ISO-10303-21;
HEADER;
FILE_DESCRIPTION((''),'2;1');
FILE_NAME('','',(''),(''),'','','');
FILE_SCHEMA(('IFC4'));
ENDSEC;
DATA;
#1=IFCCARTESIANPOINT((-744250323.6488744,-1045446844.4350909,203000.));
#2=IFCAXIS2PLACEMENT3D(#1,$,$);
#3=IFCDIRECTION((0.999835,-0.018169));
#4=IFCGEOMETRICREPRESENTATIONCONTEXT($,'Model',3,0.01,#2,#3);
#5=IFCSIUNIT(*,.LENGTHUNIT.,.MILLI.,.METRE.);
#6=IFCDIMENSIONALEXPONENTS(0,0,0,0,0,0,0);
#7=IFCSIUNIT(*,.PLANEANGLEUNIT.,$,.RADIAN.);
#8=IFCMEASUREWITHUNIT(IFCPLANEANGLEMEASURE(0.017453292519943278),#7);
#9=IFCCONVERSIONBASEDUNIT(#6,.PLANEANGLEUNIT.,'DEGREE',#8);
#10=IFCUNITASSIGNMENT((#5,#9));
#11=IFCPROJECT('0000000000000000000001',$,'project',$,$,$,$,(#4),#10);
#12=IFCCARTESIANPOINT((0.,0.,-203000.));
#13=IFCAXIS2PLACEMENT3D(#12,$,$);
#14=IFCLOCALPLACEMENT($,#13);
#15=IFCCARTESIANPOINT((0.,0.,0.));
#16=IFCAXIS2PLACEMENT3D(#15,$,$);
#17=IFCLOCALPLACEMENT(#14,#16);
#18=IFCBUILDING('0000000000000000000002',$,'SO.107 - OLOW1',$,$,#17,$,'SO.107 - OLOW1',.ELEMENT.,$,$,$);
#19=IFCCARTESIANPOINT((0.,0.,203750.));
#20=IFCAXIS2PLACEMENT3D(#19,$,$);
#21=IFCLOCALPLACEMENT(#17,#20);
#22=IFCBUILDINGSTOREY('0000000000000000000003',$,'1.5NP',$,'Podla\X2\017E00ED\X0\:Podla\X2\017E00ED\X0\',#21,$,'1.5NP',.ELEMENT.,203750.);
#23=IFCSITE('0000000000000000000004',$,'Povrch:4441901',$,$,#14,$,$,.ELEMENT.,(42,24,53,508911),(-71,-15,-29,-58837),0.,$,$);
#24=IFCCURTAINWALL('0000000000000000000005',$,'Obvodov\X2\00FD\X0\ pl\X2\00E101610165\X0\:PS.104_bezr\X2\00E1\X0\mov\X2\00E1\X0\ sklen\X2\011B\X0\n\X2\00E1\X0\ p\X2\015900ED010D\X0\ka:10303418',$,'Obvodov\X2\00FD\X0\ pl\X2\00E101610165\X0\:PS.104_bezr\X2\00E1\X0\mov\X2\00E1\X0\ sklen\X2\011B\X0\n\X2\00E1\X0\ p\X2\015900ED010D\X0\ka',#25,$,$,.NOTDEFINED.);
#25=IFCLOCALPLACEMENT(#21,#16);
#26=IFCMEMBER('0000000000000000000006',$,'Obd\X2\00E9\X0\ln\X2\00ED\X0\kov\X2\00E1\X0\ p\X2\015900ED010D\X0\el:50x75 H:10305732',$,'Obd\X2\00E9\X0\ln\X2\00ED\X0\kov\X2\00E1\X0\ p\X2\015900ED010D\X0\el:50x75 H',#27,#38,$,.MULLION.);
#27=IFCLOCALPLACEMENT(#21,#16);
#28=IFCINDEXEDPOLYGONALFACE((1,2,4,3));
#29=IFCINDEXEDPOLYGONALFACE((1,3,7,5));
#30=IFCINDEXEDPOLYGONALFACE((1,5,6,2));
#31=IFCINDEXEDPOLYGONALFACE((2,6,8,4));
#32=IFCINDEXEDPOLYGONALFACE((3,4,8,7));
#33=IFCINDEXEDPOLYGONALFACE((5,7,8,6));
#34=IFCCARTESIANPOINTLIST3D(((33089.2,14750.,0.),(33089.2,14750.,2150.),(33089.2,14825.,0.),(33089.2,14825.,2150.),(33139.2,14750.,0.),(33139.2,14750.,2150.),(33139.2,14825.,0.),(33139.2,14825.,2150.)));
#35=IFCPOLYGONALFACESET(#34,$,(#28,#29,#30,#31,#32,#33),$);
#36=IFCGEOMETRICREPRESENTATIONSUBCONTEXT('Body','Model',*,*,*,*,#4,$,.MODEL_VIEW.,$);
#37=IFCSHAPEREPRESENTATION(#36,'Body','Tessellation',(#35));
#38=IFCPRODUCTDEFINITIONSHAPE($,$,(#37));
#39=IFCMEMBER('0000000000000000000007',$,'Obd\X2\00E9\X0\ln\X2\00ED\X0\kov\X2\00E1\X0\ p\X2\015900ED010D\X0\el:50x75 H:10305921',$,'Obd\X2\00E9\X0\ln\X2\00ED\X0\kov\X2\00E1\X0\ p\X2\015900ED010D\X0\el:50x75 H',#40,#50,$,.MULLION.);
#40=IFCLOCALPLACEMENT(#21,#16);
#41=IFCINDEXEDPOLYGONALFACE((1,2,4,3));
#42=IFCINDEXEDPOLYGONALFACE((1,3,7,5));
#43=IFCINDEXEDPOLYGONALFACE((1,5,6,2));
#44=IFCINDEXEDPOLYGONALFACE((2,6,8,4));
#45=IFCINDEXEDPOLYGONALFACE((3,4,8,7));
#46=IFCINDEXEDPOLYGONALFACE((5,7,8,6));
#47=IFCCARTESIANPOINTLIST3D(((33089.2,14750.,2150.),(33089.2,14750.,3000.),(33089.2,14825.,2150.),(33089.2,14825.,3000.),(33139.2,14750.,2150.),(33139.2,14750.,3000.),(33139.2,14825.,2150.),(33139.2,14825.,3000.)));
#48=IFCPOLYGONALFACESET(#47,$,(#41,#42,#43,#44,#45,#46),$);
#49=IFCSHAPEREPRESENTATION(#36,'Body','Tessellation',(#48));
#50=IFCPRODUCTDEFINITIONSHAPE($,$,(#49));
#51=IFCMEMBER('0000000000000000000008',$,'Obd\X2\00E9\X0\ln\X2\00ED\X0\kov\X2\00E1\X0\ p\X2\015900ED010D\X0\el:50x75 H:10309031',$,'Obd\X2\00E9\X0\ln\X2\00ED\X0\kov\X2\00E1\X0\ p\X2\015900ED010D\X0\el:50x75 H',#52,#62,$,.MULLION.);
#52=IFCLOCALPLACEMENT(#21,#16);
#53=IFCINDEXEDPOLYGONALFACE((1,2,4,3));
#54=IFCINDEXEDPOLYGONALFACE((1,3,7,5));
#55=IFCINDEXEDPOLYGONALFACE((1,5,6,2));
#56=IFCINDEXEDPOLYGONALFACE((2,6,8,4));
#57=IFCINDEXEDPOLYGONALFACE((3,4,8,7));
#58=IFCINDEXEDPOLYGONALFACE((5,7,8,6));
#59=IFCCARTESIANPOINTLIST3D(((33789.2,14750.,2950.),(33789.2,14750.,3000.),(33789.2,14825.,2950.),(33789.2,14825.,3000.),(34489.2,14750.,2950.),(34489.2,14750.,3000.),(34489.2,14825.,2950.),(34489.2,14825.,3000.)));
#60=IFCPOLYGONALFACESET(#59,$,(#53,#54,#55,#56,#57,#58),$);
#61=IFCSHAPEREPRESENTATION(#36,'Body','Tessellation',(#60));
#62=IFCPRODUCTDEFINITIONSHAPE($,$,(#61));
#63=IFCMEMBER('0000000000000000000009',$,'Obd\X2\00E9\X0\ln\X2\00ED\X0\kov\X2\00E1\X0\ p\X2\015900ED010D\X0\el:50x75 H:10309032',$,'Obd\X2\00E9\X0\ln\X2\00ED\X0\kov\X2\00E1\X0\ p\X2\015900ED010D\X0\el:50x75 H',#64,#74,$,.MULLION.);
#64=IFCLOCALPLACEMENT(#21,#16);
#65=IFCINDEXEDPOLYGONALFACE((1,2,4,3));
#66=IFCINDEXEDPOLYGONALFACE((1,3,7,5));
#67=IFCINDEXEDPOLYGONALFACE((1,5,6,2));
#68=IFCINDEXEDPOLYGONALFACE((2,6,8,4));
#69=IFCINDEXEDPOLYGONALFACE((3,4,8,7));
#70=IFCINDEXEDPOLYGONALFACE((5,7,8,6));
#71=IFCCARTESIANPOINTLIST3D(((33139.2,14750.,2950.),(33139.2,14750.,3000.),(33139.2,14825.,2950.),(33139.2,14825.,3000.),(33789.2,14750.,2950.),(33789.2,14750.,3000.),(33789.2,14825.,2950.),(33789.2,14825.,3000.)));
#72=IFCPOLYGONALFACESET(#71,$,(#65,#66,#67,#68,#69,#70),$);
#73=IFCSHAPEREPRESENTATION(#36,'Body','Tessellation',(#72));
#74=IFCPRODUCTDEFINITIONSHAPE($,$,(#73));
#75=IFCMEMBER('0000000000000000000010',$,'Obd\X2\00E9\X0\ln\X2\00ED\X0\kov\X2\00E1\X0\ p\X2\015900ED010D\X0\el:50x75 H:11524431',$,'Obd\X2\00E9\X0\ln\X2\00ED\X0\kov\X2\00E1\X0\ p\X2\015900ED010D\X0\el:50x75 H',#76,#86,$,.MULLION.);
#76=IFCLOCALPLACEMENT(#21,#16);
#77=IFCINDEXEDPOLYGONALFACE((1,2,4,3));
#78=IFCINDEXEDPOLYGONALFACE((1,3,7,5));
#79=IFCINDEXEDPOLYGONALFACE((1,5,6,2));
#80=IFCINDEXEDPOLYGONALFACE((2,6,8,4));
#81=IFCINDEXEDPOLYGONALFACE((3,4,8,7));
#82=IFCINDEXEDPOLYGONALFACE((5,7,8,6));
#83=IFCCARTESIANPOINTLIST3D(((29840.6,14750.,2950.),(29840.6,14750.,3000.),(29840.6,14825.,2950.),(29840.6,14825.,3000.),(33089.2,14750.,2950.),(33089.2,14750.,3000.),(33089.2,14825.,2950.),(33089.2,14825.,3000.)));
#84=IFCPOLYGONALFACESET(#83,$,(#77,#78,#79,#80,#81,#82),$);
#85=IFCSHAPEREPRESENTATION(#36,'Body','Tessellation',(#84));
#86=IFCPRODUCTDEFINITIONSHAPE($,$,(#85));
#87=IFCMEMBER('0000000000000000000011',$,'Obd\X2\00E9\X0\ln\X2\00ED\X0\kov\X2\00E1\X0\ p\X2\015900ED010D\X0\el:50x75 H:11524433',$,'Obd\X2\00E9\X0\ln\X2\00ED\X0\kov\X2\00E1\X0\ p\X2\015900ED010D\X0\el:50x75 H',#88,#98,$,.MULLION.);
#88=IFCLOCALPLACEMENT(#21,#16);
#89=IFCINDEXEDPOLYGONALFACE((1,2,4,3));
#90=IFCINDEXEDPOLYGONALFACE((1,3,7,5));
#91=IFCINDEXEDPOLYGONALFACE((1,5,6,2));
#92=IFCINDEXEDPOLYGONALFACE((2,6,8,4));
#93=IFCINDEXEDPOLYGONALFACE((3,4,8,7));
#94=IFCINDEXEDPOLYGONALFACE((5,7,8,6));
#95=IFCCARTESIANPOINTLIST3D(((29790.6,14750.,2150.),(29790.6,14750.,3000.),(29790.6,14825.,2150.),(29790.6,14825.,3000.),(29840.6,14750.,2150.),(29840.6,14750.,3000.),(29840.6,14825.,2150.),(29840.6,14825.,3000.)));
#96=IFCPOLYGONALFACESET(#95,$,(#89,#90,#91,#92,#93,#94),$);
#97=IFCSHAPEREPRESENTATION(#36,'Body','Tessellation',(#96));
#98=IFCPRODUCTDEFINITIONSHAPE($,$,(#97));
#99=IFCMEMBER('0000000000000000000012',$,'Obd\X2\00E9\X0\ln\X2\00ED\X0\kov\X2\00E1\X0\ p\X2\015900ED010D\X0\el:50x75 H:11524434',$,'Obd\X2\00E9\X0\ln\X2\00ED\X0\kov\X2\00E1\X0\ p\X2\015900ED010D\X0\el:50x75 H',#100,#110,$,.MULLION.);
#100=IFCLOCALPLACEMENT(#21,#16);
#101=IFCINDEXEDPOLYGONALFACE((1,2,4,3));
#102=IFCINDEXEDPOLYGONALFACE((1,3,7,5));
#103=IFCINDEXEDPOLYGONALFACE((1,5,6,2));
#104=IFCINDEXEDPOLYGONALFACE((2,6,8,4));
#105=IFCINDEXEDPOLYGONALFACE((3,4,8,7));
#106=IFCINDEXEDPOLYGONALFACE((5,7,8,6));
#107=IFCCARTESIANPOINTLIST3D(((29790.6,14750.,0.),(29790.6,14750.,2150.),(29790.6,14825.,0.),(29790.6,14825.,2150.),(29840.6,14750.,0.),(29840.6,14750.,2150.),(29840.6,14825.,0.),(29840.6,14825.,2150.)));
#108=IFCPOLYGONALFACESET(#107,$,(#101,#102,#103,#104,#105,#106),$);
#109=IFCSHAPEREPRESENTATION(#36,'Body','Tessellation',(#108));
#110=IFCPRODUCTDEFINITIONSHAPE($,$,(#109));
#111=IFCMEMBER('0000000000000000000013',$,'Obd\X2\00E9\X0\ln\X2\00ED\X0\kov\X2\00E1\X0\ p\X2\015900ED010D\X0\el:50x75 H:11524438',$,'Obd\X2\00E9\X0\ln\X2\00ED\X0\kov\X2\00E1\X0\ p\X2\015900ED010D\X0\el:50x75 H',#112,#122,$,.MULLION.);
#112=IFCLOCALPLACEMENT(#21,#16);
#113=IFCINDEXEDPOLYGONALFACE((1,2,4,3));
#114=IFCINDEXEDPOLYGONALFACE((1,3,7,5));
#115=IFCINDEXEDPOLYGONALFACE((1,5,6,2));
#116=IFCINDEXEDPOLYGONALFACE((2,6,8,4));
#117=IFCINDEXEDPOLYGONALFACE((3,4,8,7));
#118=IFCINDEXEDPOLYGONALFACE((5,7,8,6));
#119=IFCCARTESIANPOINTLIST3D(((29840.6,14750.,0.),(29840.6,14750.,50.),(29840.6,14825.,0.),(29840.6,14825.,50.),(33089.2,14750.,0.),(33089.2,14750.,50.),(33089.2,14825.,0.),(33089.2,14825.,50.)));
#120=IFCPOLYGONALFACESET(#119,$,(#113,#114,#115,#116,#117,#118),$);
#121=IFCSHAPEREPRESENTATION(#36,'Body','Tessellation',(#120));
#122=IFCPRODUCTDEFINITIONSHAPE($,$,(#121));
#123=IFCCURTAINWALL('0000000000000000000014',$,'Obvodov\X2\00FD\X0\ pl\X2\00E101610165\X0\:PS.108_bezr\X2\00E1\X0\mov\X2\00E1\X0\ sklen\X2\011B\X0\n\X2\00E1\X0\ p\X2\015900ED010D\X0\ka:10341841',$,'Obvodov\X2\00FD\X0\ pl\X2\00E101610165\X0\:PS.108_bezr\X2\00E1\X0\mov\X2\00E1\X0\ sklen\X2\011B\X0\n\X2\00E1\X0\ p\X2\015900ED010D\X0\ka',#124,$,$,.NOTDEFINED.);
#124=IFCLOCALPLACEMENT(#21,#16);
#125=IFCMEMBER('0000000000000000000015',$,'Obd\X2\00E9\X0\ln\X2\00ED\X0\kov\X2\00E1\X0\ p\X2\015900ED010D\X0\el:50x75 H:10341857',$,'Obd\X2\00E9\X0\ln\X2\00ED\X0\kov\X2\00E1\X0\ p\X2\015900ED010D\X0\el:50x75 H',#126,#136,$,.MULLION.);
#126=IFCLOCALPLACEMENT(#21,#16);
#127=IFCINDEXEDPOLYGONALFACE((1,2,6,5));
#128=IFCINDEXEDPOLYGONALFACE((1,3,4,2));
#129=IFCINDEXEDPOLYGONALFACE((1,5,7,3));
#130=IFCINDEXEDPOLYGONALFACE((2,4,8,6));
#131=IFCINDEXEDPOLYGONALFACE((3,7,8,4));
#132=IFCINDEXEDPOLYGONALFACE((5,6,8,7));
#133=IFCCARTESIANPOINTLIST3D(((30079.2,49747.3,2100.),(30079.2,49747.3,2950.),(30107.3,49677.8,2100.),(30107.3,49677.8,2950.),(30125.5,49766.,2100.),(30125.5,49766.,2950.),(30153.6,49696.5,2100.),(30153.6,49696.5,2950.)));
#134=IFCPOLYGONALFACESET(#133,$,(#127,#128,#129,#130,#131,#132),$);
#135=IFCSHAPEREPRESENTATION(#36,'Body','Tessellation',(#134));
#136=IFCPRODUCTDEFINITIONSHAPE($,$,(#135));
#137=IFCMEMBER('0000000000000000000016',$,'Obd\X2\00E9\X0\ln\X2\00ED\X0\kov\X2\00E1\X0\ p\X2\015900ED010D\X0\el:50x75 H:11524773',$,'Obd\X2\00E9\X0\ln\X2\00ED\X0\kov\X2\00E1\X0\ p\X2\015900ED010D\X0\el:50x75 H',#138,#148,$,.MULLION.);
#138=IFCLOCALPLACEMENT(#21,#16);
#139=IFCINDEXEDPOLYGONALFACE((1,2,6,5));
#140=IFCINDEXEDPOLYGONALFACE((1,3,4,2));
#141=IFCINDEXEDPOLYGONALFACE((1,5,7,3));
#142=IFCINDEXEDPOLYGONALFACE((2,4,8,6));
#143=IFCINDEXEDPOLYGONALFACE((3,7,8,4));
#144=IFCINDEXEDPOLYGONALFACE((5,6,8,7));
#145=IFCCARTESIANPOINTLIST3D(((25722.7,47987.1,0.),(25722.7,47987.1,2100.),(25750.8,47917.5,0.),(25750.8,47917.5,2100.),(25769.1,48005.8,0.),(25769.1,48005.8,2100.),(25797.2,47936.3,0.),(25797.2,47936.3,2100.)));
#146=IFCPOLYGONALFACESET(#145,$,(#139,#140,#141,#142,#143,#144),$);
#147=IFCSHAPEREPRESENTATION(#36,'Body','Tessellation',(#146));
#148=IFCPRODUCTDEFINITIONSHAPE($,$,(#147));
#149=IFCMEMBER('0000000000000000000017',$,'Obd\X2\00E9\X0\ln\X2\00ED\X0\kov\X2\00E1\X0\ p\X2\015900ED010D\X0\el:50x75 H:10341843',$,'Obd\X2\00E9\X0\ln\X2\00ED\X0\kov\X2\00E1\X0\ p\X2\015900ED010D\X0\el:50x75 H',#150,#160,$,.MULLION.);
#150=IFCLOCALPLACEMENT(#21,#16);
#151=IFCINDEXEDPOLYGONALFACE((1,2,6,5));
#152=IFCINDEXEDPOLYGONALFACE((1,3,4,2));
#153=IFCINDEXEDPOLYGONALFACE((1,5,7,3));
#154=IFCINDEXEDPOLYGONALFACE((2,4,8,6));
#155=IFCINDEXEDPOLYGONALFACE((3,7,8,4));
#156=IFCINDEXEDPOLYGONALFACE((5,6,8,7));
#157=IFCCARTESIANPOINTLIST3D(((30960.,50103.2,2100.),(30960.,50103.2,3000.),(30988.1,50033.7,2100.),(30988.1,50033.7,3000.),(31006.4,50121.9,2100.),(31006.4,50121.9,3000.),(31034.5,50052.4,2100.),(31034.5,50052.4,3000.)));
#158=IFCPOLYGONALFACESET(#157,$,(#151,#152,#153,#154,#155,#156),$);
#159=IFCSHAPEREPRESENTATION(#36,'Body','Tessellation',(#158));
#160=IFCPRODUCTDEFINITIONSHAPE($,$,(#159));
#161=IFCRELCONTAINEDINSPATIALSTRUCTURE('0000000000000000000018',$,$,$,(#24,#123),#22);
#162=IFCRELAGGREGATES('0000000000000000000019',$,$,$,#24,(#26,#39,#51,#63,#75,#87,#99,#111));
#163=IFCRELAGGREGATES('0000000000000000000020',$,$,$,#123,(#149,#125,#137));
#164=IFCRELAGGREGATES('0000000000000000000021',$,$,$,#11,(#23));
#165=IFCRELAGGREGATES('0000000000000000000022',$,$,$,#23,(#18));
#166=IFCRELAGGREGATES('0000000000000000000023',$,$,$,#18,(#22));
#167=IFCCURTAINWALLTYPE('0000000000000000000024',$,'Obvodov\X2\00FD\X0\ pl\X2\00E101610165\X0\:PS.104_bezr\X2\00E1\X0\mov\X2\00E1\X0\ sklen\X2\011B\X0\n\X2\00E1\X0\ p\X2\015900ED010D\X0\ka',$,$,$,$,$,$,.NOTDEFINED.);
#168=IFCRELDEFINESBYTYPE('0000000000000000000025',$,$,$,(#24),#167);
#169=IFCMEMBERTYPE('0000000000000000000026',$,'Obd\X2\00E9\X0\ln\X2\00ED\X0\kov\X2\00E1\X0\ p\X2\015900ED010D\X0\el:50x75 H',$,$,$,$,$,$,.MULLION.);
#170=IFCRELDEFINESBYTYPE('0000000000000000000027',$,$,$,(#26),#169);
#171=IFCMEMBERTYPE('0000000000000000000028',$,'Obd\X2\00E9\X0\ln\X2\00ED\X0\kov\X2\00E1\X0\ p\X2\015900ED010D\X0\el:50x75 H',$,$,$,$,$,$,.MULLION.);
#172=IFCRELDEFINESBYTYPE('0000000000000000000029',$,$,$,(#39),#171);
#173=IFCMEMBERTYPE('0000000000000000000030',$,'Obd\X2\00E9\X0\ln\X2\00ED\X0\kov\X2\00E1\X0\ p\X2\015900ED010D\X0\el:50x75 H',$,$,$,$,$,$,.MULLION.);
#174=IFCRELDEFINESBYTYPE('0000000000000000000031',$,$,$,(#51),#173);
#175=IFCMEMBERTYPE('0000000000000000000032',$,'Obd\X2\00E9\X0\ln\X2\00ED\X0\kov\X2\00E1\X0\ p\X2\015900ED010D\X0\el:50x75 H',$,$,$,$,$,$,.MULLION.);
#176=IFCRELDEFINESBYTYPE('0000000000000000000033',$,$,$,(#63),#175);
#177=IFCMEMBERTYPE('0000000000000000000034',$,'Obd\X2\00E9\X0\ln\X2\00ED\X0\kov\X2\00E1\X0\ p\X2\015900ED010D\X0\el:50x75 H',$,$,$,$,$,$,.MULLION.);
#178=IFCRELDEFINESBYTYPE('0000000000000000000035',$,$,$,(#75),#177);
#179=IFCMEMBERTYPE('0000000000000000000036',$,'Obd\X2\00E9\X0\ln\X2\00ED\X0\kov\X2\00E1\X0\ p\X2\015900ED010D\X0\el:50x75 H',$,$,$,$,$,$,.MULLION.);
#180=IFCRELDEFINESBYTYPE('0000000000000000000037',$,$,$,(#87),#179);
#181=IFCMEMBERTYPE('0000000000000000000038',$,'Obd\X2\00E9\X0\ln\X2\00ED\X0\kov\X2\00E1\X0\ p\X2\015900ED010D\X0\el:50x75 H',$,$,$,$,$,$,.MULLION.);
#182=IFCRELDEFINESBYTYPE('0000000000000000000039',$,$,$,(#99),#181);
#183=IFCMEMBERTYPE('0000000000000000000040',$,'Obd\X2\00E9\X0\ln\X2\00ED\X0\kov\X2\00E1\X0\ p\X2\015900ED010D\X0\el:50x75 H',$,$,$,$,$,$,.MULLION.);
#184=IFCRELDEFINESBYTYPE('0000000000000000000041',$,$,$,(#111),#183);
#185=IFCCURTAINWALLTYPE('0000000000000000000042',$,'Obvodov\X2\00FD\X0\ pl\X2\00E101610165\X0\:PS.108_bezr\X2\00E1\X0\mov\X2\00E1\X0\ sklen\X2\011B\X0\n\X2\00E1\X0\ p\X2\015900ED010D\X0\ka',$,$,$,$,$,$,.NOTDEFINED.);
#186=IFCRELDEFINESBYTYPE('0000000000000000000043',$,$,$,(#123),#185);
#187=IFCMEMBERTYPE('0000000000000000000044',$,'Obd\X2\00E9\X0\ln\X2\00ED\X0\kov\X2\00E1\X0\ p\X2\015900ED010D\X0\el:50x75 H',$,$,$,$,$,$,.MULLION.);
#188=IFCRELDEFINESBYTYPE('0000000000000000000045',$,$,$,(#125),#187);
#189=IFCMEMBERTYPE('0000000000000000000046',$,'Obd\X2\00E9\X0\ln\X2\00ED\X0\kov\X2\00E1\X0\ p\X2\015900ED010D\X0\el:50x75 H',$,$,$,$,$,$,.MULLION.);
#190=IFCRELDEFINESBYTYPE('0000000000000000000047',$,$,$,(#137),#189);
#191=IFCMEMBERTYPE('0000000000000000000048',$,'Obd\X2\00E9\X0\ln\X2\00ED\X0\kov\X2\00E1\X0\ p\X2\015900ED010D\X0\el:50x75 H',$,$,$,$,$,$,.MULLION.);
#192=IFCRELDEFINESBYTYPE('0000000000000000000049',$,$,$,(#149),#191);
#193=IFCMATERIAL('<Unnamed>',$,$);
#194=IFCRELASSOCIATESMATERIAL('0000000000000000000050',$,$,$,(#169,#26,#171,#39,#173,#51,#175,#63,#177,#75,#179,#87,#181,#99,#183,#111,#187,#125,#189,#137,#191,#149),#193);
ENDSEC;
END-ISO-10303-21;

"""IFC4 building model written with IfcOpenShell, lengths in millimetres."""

from ifc_helpers import new_model, entity, si_unit, converted_unit, direction, frame, origin, place, context, subcontext, project, spatial, indexed_curve, outline, extrude, source, transform, mapped, material, type_object, type_shapes, element, aggregate, save


model = new_model("IFC4")

# Units and contexts
model_context = context("Model", 3, precision=0.01, world=frame((-744250323.6488744, -1045446844.4350909, 203000.0)), true_north=direction((0.999835, -0.018169)))
body_context = subcontext(model_context, "Body", "Model", "MODEL_VIEW")
ifc_project = project(units=[si_unit("LENGTHUNIT", "METRE", prefix="MILLI"), converted_unit("PLANEANGLEUNIT", "DEGREE", entity("IfcPlaneAngleMeasure", 0.017453292519943278), si_unit("PLANEANGLEUNIT", "RADIAN"), dimensions=[0, 0, 0, 0, 0, 0, 0])], contexts=[model_context])

# Site, building, storey
site_placement = place(None, frame((0.0, 0.0, -203000.0)))
site = spatial("IfcSite", under=ifc_project, at=site_placement, Name="Povrch:4441901", CompositionType="ELEMENT", RefLatitude=(42, 24, 53, 508911), RefLongitude=(-71, -15, -29, -58837), RefElevation=0.0)
building_placement = place(site_placement, origin())
building = spatial("IfcBuilding", under=site, at=building_placement, Name="SO.107 - OLOW1", LongName="SO.107 - OLOW1", CompositionType="ELEMENT")
storey_placement = place(building_placement, frame((0.0, 0.0, 203750.0)))
storey = spatial("IfcBuildingStorey", under=building, at=storey_placement, Name="1.5NP", ObjectType="Podlaží:Podlaží", LongName="1.5NP", CompositionType="ELEMENT", Elevation=203750.0)

# Curtain walls, members
curtain_wall_type_1 = type_object("IfcCurtainWallType", Name="Obvodový plášť:PS.104_bezrámová skleněná příčka", PredefinedType="NOTDEFINED")
curtain_wall_1_placement = place(storey_placement, frame((0.0, 0.0, -203750.0)))
curtain_wall_1 = element("IfcCurtainWall", 1, at=curtain_wall_1_placement, inside=storey, type_object=curtain_wall_type_1, Name="Obvodový plášť:PS.104_bezrámová skleněná příčka:10303418", ObjectType="Obvodový plášť:PS.104_bezrámová skleněná příčka", PredefinedType="NOTDEFINED")
ifc_material_1 = material(Name="<Unnamed>")
member_type_1 = type_object("IfcMemberType", Name="Obdélníková příčel:50x75 H", PredefinedType="MULLION", material=ifc_material_1)
shared_shape_1 = source(origin(), body_context, "Body", "SweptSolid", [
    extrude(outline(indexed_curve([(-25.0, -37.5), (25.0, -37.5), (25.0, 37.5), (-25.0, 37.5), (-25.0, -37.5)], self_intersect=False)), frame((-25.0, 37.5, -2150.0), z_axis=(0.0, 0.0, 1.0), x_axis=(-1.0, 0.0, 0.0)), (0.0, 0.0, 1.0), 2150.0),
])
type_shapes(member_type_1, [shared_shape_1])
member_1_placement = place(curtain_wall_1_placement, frame((33089.2, 14750.0, 203750.0), z_axis=(0.0, 0.0, -1.0), x_axis=(-1.0, 0.0, 0.0)))
member_1 = element("IfcMember", 2, at=member_1_placement, type_object=member_type_1, material=ifc_material_1, Name="Obdélníková příčel:50x75 H:10305732", ObjectType="Obdélníková příčel:50x75 H", PredefinedType="MULLION", context=body_context, shape_type="MappedRepresentation", body=[
    mapped(shared_shape_1, transform((0.0, 0.0, 0.0), scale=1.0)),
])
member_type_2 = type_object("IfcMemberType", Name="Obdélníková příčel:50x75 H", PredefinedType="MULLION", material=ifc_material_1)
shared_shape_2 = source(origin(), body_context, "Body", "SweptSolid", [
    extrude(outline(indexed_curve([(-25.0, -37.5), (25.0, -37.5), (25.0, 37.5), (-25.0, 37.5), (-25.0, -37.5)], self_intersect=False)), frame((-25.0, 37.5, -850.0), z_axis=(0.0, 0.0, 1.0), x_axis=(-1.0, 0.0, 0.0)), (0.0, 0.0, 1.0), 850.0),
])
type_shapes(member_type_2, [shared_shape_2])
member_2_placement = place(curtain_wall_1_placement, frame((33089.2, 14750.0, 205900.0), z_axis=(0.0, 0.0, -1.0), x_axis=(-1.0, 0.0, 0.0)))
member_2 = element("IfcMember", 3, at=member_2_placement, type_object=member_type_2, material=ifc_material_1, Name="Obdélníková příčel:50x75 H:10305921", ObjectType="Obdélníková příčel:50x75 H", PredefinedType="MULLION", context=body_context, shape_type="MappedRepresentation", body=[
    mapped(shared_shape_2, transform((0.0, 0.0, 0.0), scale=1.0)),
])
member_type_3 = type_object("IfcMemberType", Name="Obdélníková příčel:50x75 H", PredefinedType="MULLION", material=ifc_material_1)
shared_shape_3 = source(origin(), body_context, "Body", "SweptSolid", [
    extrude(outline(indexed_curve([(-25.0, -37.5), (25.0, -37.5), (25.0, 37.5), (-25.0, 37.5), (-25.0, -37.5)], self_intersect=False)), frame((-25.0, 37.5, -700.0), z_axis=(0.0, 0.0, 1.0), x_axis=(-1.0, 0.0, 0.0)), (0.0, 0.0, 1.0), 700.0),
])
type_shapes(member_type_3, [shared_shape_3])
member_3_placement = place(curtain_wall_1_placement, frame((33789.2, 14750.0, 206750.0), z_axis=(-1.0, 0.0, 0.0), x_axis=(0.0, 0.0, 1.0)))
member_3 = element("IfcMember", 4, at=member_3_placement, type_object=member_type_3, material=ifc_material_1, Name="Obdélníková příčel:50x75 H:10309031", ObjectType="Obdélníková příčel:50x75 H", PredefinedType="MULLION", context=body_context, shape_type="MappedRepresentation", body=[
    mapped(shared_shape_3, transform((0.0, 0.0, 0.0), scale=1.0)),
])
member_type_4 = type_object("IfcMemberType", Name="Obdélníková příčel:50x75 H", PredefinedType="MULLION", material=ifc_material_1)
shared_shape_4 = source(origin(), body_context, "Body", "SweptSolid", [
    extrude(outline(indexed_curve([(-25.0, -37.5), (25.0, -37.5), (25.0, 37.5), (-25.0, 37.5), (-25.0, -37.5)], self_intersect=False)), frame((-25.0, 37.5, -650.0), z_axis=(0.0, 0.0, 1.0), x_axis=(-1.0, 0.0, 0.0)), (0.0, 0.0, 1.0), 650.0),
])
type_shapes(member_type_4, [shared_shape_4])
member_4_placement = place(curtain_wall_1_placement, frame((33139.2, 14750.0, 206750.0), z_axis=(-1.0, 0.0, 0.0), x_axis=(0.0, 0.0, 1.0)))
member_4 = element("IfcMember", 5, at=member_4_placement, type_object=member_type_4, material=ifc_material_1, Name="Obdélníková příčel:50x75 H:10309032", ObjectType="Obdélníková příčel:50x75 H", PredefinedType="MULLION", context=body_context, shape_type="MappedRepresentation", body=[
    mapped(shared_shape_4, transform((0.0, 0.0, 0.0), scale=1.0)),
])
member_type_5 = type_object("IfcMemberType", Name="Obdélníková příčel:50x75 H", PredefinedType="MULLION", material=ifc_material_1)
shared_shape_5 = source(origin(), body_context, "Body", "SweptSolid", [
    extrude(outline(indexed_curve([(-25.0, -37.5), (25.0, -37.5), (25.0, 37.5), (-25.0, 37.5), (-25.0, -37.5)], self_intersect=False)), frame((-25.0, 37.5, -3248.6), z_axis=(0.0, 0.0, 1.0), x_axis=(-1.0, 0.0, 0.0)), (0.0, 0.0, 1.0), 3248.6),
])
type_shapes(member_type_5, [shared_shape_5])
member_5_placement = place(curtain_wall_1_placement, frame((29840.6, 14750.0, 206750.0), z_axis=(-1.0, 0.0, 0.0), x_axis=(0.0, 0.0, 1.0)))
member_5 = element("IfcMember", 6, at=member_5_placement, type_object=member_type_5, material=ifc_material_1, Name="Obdélníková příčel:50x75 H:11524431", ObjectType="Obdélníková příčel:50x75 H", PredefinedType="MULLION", context=body_context, shape_type="MappedRepresentation", body=[
    mapped(shared_shape_5, transform((0.0, 0.0, 0.0), scale=1.0)),
])
member_type_6 = type_object("IfcMemberType", Name="Obdélníková příčel:50x75 H", PredefinedType="MULLION", material=ifc_material_1)
shared_shape_6 = source(origin(), body_context, "Body", "SweptSolid", [
    extrude(outline(indexed_curve([(-25.0, -37.5), (25.0, -37.5), (25.0, 37.5), (-25.0, 37.5), (-25.0, -37.5)], self_intersect=False)), frame((-25.0, 37.5, -850.0), z_axis=(0.0, 0.0, 1.0), x_axis=(-1.0, 0.0, 0.0)), (0.0, 0.0, 1.0), 850.0),
])
type_shapes(member_type_6, [shared_shape_6])
member_6_placement = place(curtain_wall_1_placement, frame((29790.6, 14750.0, 205900.0), z_axis=(0.0, 0.0, -1.0), x_axis=(-1.0, 0.0, 0.0)))
member_6 = element("IfcMember", 7, at=member_6_placement, type_object=member_type_6, material=ifc_material_1, Name="Obdélníková příčel:50x75 H:11524433", ObjectType="Obdélníková příčel:50x75 H", PredefinedType="MULLION", context=body_context, shape_type="MappedRepresentation", body=[
    mapped(shared_shape_6, transform((0.0, 0.0, 0.0), scale=1.0)),
])
member_type_7 = type_object("IfcMemberType", Name="Obdélníková příčel:50x75 H", PredefinedType="MULLION", material=ifc_material_1)
shared_shape_7 = source(origin(), body_context, "Body", "SweptSolid", [
    extrude(outline(indexed_curve([(-25.0, -37.5), (25.0, -37.5), (25.0, 37.5), (-25.0, 37.5), (-25.0, -37.5)], self_intersect=False)), frame((-25.0, 37.5, -2150.0), z_axis=(0.0, 0.0, 1.0), x_axis=(-1.0, 0.0, 0.0)), (0.0, 0.0, 1.0), 2150.0),
])
type_shapes(member_type_7, [shared_shape_7])
member_7_placement = place(curtain_wall_1_placement, frame((29790.6, 14750.0, 203750.0), z_axis=(0.0, 0.0, -1.0), x_axis=(-1.0, 0.0, 0.0)))
member_7 = element("IfcMember", 8, at=member_7_placement, type_object=member_type_7, material=ifc_material_1, Name="Obdélníková příčel:50x75 H:11524434", ObjectType="Obdélníková příčel:50x75 H", PredefinedType="MULLION", context=body_context, shape_type="MappedRepresentation", body=[
    mapped(shared_shape_7, transform((0.0, 0.0, 0.0), scale=1.0)),
])
member_type_8 = type_object("IfcMemberType", Name="Obdélníková příčel:50x75 H", PredefinedType="MULLION", material=ifc_material_1)
shared_shape_8 = source(origin(), body_context, "Body", "SweptSolid", [
    extrude(outline(indexed_curve([(-25.0, -37.5), (25.0, -37.5), (25.0, 37.5), (-25.0, 37.5), (-25.0, -37.5)], self_intersect=False)), frame((-25.0, 37.5, -3248.6), z_axis=(0.0, 0.0, 1.0), x_axis=(-1.0, 0.0, 0.0)), (0.0, 0.0, 1.0), 3248.6),
])
type_shapes(member_type_8, [shared_shape_8])
member_8_placement = place(curtain_wall_1_placement, frame((33089.2, 14750.0, 203750.0), z_axis=(1.0, 0.0, 0.0), x_axis=(0.0, 0.0, -1.0)))
member_8 = element("IfcMember", 9, at=member_8_placement, type_object=member_type_8, material=ifc_material_1, Name="Obdélníková příčel:50x75 H:11524438", ObjectType="Obdélníková příčel:50x75 H", PredefinedType="MULLION", context=body_context, shape_type="MappedRepresentation", body=[
    mapped(shared_shape_8, transform((0.0, 0.0, 0.0), scale=1.0)),
])
curtain_wall_type_2 = type_object("IfcCurtainWallType", Name="Obvodový plášť:PS.108_bezrámová skleněná příčka", PredefinedType="NOTDEFINED")
curtain_wall_2_placement = place(storey_placement, frame((0.0, 0.0, -203750.0)))
curtain_wall_2 = element("IfcCurtainWall", 10, at=curtain_wall_2_placement, inside=storey, type_object=curtain_wall_type_2, Name="Obvodový plášť:PS.108_bezrámová skleněná příčka:10341841", ObjectType="Obvodový plášť:PS.108_bezrámová skleněná příčka", PredefinedType="NOTDEFINED")
member_type_9 = type_object("IfcMemberType", Name="Obdélníková příčel:50x75 H", PredefinedType="MULLION", material=ifc_material_1)
shared_shape_9 = source(origin(), body_context, "Body", "SweptSolid", [
    extrude(outline(indexed_curve([(-25.0, -37.5), (25.0, -37.5), (25.0, 37.5), (-25.0, 37.5), (-25.0, -37.5)], self_intersect=False)), frame((-25.0, -37.5, -850.0), z_axis=(0.0, 0.0, 1.0), x_axis=(-1.0, 0.0, 0.0)), (0.0, 0.0, 1.0), 850.0),
])
type_shapes(member_type_9, [shared_shape_9])
member_9_placement = place(curtain_wall_2_placement, frame((30079.2, 49747.3, 205850.0), z_axis=(0.0, 0.0, -1.0), x_axis=(-0.927176, -0.374626, 0.0)))
member_9 = element("IfcMember", 11, at=member_9_placement, type_object=member_type_9, material=ifc_material_1, Name="Obdélníková příčel:50x75 H:10341857", ObjectType="Obdélníková příčel:50x75 H", PredefinedType="MULLION", context=body_context, shape_type="MappedRepresentation", body=[
    mapped(shared_shape_9, transform((0.0, 0.0, 0.0), scale=1.0)),
])
member_type_10 = type_object("IfcMemberType", Name="Obdélníková příčel:50x75 H", PredefinedType="MULLION", material=ifc_material_1)
shared_shape_10 = source(origin(), body_context, "Body", "SweptSolid", [
    extrude(outline(indexed_curve([(-25.0, -37.5), (25.0, -37.5), (25.0, 37.5), (-25.0, 37.5), (-25.0, -37.5)], self_intersect=False)), frame((-25.0, -37.5, -2100.0), z_axis=(0.0, 0.0, 1.0), x_axis=(-1.0, 0.0, 0.0)), (0.0, 0.0, 1.0), 2100.0),
])
type_shapes(member_type_10, [shared_shape_10])
member_10_placement = place(curtain_wall_2_placement, frame((25722.7, 47987.1, 203750.0), z_axis=(0.0, 0.0, -1.0), x_axis=(-0.927176, -0.374626, 0.0)))
member_10 = element("IfcMember", 12, at=member_10_placement, type_object=member_type_10, material=ifc_material_1, Name="Obdélníková příčel:50x75 H:11524773", ObjectType="Obdélníková příčel:50x75 H", PredefinedType="MULLION", context=body_context, shape_type="MappedRepresentation", body=[
    mapped(shared_shape_10, transform((0.0, 0.0, 0.0), scale=1.0)),
])
member_type_11 = type_object("IfcMemberType", Name="Obdélníková příčel:50x75 H", PredefinedType="MULLION", material=ifc_material_1)
shared_shape_11 = source(origin(), body_context, "Body", "SweptSolid", [
    extrude(outline(indexed_curve([(-25.0, -37.5), (25.0, -37.5), (25.0, 37.5), (-25.0, 37.5), (-25.0, -37.5)], self_intersect=False)), frame((-25.0, -37.5, -900.0), z_axis=(0.0, 0.0, 1.0), x_axis=(-1.0, 0.0, 0.0)), (0.0, 0.0, 1.0), 900.0),
])
type_shapes(member_type_11, [shared_shape_11])
member_11_placement = place(curtain_wall_2_placement, frame((31006.4, 50121.9, 206750.0), z_axis=(0.0, 0.0, 1.0), x_axis=(0.927176, 0.374626, 0.0)))
member_11 = element("IfcMember", 13, at=member_11_placement, type_object=member_type_11, material=ifc_material_1, Name="Obdélníková příčel:50x75 H:10341843", ObjectType="Obdélníková příčel:50x75 H", PredefinedType="MULLION", context=body_context, shape_type="MappedRepresentation", body=[
    mapped(shared_shape_11, transform((0.0, 0.0, 0.0), scale=1.0)),
])

aggregate(curtain_wall_1, [member_1, member_2, member_3, member_4, member_5, member_6, member_7, member_8])

aggregate(curtain_wall_2, [member_11, member_9, member_10])

save(model, "model.ifc")
